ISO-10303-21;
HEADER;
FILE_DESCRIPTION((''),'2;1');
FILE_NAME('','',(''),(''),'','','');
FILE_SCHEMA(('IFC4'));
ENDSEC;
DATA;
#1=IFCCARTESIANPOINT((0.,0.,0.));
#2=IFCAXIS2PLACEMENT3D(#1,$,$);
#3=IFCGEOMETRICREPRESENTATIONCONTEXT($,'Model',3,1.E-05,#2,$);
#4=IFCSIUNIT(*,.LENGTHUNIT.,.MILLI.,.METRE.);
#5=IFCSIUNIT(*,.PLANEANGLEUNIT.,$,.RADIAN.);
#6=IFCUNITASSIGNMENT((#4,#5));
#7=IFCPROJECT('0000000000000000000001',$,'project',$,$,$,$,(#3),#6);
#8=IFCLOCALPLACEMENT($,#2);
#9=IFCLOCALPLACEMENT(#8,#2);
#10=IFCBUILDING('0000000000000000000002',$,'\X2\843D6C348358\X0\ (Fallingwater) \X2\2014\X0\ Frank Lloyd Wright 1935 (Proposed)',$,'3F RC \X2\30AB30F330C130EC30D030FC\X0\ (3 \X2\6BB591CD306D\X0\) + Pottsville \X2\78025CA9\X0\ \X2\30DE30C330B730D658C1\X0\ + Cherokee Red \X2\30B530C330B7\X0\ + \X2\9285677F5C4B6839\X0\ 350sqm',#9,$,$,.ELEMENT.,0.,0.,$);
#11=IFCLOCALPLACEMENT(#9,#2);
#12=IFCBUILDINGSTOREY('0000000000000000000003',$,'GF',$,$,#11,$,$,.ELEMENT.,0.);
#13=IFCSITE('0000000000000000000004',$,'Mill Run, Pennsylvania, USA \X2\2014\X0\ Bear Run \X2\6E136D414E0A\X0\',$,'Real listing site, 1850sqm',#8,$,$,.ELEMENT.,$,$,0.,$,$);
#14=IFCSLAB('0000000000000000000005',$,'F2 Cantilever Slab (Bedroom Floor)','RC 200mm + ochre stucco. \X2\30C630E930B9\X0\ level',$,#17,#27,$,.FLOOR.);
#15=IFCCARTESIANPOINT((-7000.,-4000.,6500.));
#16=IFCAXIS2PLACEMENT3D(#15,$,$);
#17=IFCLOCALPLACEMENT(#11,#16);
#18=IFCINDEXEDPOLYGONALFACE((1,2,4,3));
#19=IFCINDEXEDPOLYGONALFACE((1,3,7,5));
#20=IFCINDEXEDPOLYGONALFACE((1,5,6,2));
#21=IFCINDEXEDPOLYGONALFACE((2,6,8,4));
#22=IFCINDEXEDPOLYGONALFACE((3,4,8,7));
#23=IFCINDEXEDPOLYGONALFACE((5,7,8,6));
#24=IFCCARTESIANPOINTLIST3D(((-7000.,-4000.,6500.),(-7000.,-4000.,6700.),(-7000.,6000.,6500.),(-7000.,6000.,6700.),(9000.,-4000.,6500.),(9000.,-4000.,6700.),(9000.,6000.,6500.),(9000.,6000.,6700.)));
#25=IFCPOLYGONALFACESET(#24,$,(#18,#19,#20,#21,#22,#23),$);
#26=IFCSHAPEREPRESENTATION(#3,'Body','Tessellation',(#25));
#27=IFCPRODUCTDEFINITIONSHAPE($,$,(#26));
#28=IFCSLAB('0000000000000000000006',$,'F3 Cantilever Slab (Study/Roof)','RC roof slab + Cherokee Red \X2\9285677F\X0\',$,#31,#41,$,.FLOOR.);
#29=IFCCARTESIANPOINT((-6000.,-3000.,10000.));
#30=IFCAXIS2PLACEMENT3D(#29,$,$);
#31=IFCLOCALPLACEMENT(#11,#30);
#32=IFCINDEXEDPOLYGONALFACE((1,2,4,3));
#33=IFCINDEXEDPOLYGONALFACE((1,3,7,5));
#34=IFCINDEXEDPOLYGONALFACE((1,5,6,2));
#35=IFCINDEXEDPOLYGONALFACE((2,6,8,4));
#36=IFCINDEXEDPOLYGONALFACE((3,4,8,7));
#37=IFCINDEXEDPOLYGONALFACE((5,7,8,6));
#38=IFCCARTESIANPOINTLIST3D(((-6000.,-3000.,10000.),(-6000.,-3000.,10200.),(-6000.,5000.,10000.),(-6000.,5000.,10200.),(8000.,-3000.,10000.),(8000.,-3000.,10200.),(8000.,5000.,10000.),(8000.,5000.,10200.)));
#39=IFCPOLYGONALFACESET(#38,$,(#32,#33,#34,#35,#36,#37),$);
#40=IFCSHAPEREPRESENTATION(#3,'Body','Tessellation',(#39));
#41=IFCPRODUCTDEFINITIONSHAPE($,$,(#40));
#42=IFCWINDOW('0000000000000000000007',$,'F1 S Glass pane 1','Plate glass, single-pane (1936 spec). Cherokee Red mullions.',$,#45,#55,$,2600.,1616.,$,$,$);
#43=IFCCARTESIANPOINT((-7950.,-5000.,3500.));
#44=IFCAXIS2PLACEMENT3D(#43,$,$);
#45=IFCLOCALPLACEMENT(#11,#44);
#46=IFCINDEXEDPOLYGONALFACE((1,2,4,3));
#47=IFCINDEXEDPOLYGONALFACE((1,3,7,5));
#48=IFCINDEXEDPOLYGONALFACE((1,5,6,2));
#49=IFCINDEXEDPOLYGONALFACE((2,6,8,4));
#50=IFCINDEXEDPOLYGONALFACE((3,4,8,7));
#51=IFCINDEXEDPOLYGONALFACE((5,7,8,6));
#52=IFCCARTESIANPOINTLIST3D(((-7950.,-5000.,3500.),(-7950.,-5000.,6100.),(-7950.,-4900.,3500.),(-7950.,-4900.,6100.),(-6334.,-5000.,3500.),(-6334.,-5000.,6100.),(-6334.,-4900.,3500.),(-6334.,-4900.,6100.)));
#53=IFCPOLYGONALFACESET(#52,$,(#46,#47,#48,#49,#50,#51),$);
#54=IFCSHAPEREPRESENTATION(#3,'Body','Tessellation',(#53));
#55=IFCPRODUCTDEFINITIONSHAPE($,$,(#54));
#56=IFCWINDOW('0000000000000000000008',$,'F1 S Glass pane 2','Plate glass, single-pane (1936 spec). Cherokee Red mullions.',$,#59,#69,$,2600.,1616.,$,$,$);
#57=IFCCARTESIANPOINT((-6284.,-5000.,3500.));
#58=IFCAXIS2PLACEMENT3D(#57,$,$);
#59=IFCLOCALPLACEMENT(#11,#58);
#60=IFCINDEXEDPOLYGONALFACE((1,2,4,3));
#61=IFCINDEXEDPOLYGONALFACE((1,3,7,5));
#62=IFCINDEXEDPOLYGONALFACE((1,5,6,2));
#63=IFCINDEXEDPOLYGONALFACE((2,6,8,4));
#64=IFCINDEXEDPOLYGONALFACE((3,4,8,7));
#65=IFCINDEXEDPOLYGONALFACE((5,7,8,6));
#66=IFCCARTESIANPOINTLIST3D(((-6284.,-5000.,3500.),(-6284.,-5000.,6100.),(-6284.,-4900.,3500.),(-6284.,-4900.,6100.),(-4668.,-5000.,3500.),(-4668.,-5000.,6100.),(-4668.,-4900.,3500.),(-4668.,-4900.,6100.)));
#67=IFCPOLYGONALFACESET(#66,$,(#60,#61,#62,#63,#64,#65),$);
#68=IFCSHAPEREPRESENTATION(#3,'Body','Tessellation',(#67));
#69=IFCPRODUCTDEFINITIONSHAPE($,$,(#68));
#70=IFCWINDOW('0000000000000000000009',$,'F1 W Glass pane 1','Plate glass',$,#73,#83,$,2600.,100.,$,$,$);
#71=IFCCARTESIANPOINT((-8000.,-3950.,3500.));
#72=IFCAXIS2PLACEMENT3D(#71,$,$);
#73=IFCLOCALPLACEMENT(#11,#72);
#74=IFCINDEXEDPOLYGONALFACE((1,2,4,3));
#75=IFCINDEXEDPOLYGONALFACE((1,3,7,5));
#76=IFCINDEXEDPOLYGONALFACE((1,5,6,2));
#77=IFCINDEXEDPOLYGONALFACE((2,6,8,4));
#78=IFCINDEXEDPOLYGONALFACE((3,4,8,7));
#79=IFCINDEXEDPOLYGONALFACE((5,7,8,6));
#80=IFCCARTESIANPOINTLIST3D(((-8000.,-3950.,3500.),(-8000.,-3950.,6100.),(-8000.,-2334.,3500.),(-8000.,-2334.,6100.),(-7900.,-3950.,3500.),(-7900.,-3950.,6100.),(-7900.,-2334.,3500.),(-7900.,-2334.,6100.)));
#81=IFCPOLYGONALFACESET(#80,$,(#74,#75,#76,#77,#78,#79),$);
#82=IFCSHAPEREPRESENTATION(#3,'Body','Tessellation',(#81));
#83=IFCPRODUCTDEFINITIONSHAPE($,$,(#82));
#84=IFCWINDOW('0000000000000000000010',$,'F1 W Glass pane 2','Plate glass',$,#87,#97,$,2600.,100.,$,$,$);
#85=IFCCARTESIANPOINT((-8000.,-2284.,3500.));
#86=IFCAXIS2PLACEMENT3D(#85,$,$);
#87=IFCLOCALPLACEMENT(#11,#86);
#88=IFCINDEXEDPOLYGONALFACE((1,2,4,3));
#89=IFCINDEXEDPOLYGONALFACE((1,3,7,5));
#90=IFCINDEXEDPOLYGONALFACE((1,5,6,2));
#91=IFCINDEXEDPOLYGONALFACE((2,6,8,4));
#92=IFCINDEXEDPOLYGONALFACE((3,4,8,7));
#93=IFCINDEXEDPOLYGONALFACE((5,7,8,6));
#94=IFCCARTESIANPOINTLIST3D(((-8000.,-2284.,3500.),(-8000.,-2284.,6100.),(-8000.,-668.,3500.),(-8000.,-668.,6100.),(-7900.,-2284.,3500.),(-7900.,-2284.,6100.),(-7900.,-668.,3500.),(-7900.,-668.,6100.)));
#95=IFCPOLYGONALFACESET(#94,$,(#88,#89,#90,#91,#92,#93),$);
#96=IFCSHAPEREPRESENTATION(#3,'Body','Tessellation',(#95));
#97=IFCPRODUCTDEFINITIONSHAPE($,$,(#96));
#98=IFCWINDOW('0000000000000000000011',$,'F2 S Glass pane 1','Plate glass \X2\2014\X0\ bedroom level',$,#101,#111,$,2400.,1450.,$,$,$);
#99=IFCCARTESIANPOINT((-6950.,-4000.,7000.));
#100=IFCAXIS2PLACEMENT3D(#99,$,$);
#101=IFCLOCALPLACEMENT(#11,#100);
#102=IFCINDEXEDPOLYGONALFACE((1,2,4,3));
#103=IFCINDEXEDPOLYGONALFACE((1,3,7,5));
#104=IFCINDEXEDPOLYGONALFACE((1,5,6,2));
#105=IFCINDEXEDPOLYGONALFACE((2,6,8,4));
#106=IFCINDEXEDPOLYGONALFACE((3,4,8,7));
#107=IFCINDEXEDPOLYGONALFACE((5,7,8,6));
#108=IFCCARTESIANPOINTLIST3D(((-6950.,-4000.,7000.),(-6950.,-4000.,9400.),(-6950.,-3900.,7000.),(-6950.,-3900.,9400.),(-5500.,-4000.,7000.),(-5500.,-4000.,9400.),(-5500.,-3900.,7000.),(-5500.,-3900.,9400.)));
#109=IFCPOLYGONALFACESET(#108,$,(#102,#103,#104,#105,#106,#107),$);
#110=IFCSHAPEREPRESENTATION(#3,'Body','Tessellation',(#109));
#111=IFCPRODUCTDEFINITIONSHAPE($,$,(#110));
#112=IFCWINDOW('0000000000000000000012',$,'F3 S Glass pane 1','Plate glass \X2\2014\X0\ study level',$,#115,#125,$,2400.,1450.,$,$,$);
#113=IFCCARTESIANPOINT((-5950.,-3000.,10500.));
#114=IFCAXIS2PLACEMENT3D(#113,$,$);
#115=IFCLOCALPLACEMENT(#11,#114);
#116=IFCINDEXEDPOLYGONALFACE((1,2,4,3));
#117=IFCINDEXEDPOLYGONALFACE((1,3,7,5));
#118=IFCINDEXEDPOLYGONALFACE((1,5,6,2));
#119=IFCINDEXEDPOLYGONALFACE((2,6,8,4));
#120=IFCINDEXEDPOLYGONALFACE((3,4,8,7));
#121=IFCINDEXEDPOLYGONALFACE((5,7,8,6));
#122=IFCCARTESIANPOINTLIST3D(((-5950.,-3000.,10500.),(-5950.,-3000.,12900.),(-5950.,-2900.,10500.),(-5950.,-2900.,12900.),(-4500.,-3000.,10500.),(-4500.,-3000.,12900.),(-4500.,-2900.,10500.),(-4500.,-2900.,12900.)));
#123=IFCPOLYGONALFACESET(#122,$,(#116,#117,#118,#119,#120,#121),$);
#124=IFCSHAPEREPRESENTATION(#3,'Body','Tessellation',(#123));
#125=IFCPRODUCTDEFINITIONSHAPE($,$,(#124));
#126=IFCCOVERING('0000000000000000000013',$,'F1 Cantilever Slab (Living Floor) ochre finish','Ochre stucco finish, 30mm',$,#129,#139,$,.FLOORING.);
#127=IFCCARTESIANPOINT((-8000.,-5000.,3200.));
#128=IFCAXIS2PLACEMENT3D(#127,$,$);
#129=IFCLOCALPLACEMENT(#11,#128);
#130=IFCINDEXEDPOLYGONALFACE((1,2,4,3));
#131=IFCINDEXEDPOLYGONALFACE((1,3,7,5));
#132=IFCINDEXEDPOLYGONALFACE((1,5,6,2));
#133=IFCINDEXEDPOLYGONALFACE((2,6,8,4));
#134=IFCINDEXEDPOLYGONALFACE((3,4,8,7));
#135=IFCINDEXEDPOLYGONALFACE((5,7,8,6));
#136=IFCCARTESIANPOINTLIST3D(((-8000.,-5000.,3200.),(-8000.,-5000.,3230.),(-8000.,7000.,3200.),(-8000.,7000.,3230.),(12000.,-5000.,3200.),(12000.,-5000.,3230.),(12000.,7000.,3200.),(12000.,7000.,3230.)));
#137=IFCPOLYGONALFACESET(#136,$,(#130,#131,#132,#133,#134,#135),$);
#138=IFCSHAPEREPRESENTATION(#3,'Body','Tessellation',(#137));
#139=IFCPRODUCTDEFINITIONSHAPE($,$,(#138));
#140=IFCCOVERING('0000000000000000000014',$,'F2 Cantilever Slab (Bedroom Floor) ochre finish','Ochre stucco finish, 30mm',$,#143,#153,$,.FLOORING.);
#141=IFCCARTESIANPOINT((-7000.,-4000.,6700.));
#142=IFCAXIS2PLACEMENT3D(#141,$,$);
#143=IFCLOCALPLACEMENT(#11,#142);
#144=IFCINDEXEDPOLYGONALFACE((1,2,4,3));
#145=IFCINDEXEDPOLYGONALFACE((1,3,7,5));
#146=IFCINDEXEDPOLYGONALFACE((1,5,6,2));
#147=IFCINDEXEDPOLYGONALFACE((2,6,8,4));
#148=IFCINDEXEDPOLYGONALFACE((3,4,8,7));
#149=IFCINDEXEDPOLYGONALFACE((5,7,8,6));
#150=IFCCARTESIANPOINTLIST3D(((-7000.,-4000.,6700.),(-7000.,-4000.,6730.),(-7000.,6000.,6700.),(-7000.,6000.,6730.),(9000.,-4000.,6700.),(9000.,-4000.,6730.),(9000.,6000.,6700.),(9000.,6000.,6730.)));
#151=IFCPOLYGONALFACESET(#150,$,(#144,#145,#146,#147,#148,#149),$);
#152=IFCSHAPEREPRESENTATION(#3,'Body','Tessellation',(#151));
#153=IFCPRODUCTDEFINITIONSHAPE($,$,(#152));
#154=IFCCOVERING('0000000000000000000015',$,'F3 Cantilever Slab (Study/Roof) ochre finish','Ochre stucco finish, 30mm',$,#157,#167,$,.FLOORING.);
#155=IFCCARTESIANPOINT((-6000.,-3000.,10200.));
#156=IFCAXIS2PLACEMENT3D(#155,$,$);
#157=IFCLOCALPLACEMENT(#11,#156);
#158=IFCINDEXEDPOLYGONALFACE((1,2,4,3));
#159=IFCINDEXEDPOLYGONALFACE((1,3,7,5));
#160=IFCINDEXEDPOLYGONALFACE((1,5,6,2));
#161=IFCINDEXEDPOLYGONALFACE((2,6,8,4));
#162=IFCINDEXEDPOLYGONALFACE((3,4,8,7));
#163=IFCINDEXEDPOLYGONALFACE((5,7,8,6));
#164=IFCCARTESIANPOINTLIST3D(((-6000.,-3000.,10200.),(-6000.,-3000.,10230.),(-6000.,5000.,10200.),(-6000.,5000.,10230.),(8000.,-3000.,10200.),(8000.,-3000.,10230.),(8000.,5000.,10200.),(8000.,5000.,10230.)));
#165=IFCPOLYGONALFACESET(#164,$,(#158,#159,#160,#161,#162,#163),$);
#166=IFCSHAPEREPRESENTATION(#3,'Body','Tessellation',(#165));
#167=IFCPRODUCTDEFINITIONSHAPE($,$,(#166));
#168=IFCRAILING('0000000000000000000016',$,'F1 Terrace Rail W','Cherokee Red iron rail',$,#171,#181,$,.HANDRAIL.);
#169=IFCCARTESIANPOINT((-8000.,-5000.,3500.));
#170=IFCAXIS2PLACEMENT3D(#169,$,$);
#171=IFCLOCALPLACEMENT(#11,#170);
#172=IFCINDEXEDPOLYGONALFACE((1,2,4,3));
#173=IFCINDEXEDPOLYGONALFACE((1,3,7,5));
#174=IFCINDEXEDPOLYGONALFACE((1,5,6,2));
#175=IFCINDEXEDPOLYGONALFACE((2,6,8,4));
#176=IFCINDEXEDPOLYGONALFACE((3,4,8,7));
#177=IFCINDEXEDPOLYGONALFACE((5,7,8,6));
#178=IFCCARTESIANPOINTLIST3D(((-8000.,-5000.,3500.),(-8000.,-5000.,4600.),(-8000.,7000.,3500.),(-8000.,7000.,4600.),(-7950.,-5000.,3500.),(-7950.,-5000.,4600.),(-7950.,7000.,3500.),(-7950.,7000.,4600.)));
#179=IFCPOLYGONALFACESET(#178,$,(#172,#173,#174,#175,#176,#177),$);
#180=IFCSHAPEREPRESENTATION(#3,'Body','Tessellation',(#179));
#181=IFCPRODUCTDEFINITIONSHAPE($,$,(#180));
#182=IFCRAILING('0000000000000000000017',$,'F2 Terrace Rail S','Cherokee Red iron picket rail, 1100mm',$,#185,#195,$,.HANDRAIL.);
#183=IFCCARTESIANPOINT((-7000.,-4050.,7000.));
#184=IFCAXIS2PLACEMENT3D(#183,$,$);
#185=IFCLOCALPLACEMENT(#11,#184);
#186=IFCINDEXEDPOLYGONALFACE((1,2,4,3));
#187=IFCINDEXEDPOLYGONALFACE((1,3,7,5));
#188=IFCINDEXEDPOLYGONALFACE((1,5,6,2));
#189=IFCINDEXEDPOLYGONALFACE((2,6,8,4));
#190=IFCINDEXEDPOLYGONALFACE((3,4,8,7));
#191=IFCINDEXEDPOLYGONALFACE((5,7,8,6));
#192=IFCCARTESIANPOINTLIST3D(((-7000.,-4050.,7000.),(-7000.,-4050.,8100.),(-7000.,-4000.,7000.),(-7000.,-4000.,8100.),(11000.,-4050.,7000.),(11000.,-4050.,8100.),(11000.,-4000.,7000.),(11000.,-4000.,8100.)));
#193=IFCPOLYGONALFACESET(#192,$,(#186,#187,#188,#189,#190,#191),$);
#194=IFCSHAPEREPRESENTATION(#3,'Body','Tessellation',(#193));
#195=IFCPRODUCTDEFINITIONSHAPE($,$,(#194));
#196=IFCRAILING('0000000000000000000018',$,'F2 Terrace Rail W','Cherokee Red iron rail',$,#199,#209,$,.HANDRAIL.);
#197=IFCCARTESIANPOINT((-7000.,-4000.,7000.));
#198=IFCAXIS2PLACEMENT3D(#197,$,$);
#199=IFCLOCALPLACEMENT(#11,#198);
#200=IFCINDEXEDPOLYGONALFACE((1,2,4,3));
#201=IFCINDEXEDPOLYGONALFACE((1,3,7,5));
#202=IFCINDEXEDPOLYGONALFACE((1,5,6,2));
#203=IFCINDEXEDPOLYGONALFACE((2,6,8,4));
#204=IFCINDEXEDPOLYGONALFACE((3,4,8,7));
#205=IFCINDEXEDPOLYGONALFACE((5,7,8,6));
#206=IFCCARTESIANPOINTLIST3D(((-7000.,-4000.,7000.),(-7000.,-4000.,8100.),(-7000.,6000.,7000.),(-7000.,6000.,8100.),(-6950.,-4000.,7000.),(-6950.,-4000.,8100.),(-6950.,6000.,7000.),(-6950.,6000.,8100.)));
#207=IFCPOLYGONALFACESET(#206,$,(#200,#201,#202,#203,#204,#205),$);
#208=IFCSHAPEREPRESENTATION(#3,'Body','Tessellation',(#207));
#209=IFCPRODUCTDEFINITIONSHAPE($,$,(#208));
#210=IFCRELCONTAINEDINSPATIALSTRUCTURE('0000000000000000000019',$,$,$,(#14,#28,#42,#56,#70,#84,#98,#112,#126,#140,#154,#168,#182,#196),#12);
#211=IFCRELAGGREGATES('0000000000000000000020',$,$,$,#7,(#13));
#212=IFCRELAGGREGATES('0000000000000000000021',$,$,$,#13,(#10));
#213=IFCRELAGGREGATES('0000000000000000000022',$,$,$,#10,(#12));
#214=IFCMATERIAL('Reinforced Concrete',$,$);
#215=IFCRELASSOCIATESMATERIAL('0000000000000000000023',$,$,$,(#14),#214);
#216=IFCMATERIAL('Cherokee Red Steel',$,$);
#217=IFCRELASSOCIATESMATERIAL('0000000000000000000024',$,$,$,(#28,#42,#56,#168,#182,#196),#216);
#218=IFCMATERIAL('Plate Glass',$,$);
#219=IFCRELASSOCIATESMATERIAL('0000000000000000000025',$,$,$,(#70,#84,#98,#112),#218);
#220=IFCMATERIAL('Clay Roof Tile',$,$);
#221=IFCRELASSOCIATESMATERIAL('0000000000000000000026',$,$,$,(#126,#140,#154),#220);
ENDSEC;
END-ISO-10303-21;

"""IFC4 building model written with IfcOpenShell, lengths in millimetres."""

from ifc_helpers import new_model, si_unit, frame, frame_2d, origin, place, context, project, spatial, rectangle, extrude, material, element, save


model = new_model("IFC4")

# Units and contexts
model_context = context("Model", 3, precision=1e-05, world=origin())
ifc_project = project(units=[si_unit("LENGTHUNIT", "METRE", prefix="MILLI"), si_unit("PLANEANGLEUNIT", "RADIAN")], contexts=[model_context])

# Site, building, storey
site_placement = place(None, origin())
site = spatial("IfcSite", under=ifc_project, at=site_placement, Name="Mill Run, Pennsylvania, USA — Bear Run 渓流上", ObjectType="Real listing site, 1850sqm", CompositionType="ELEMENT", RefElevation=0.0)
building_placement = place(site_placement, origin())
building = spatial("IfcBuilding", under=site, at=building_placement, Name="落水荘 (Fallingwater) — Frank Lloyd Wright 1935 (Proposed)", ObjectType="3F RC カンチレバー (3 段重ね) + Pottsville 砂岩 マッシブ壁 + Cherokee Red サッシ + 銅板屋根 350sqm", CompositionType="ELEMENT", ElevationOfRefHeight=0.0, ElevationOfTerrain=0.0)
storey_placement = place(building_placement, origin())
storey = spatial("IfcBuildingStorey", under=building, at=storey_placement, Name="GF", CompositionType="ELEMENT", Elevation=0.0)

# Slabs
ifc_material_1 = material(Name="Reinforced Concrete")
slab_1_placement = place(storey_placement, frame((-7000.0, -4000.0, 6500.0)))
element("IfcSlab", 1, at=slab_1_placement, inside=storey, material=ifc_material_1, Name="F2 Cantilever Slab (Bedroom Floor)", Description="RC 200mm + ochre stucco. テラス level", PredefinedType="FLOOR", context=model_context, shape_type="SweptSolid", body=[
    extrude(rectangle(XDim=16000.0, YDim=10000.0, at=frame_2d((8000.0, 5000.0))), frame((-7000.0, -4000.0, 6500.0)), (0.0, 0.0, 1.0), 200.0),
])
ifc_material_2 = material(Name="Cherokee Red Steel")
slab_2_placement = place(storey_placement, frame((-6000.0, -3000.0, 10000.0)))
element("IfcSlab", 2, at=slab_2_placement, inside=storey, material=ifc_material_2, Name="F3 Cantilever Slab (Study/Roof)", Description="RC roof slab + Cherokee Red 銅板", PredefinedType="FLOOR", context=model_context, shape_type="SweptSolid", body=[
    extrude(rectangle(XDim=14000.0, YDim=8000.0, at=frame_2d((7000.0, 4000.0))), frame((-6000.0, -3000.0, 10000.0)), (0.0, 0.0, 1.0), 200.0),
])

# Windows
window_1_placement = place(storey_placement, frame((-7950.0, -5000.0, 3500.0)))
element("IfcWindow", 3, at=window_1_placement, inside=storey, material=ifc_material_2, Name="F1 S Glass pane 1", Description="Plate glass, single-pane (1936 spec). Cherokee Red mullions.", OverallHeight=2600.0, OverallWidth=1616.0, context=model_context, shape_type="SweptSolid", body=[
    extrude(rectangle(XDim=1616.0, YDim=100.0, at=frame_2d((808.0, 50.0))), frame((-7950.0, -5000.0, 3500.0)), (0.0, 0.0, 1.0), 2600.0),
])
window_2_placement = place(storey_placement, frame((-6284.0, -5000.0, 3500.0)))
element("IfcWindow", 4, at=window_2_placement, inside=storey, material=ifc_material_2, Name="F1 S Glass pane 2", Description="Plate glass, single-pane (1936 spec). Cherokee Red mullions.", OverallHeight=2600.0, OverallWidth=1616.0, context=model_context, shape_type="SweptSolid", body=[
    extrude(rectangle(XDim=1616.0, YDim=100.0, at=frame_2d((808.0, 50.0))), frame((-6284.0, -5000.0, 3500.0)), (0.0, 0.0, 1.0), 2600.0),
])
ifc_material_3 = material(Name="Plate Glass")
window_3_placement = place(storey_placement, frame((-8000.0, -3950.0, 3500.0)))
element("IfcWindow", 5, at=window_3_placement, inside=storey, material=ifc_material_3, Name="F1 W Glass pane 1", Description="Plate glass", OverallHeight=2600.0, OverallWidth=100.0, context=model_context, shape_type="SweptSolid", body=[
    extrude(rectangle(XDim=100.0, YDim=1616.0, at=frame_2d((50.0, 808.0))), frame((-8000.0, -3950.0, 3500.0)), (0.0, 0.0, 1.0), 2600.0),
])
window_4_placement = place(storey_placement, frame((-8000.0, -2284.0, 3500.0)))
element("IfcWindow", 6, at=window_4_placement, inside=storey, material=ifc_material_3, Name="F1 W Glass pane 2", Description="Plate glass", OverallHeight=2600.0, OverallWidth=100.0, context=model_context, shape_type="SweptSolid", body=[
    extrude(rectangle(XDim=100.0, YDim=1616.0, at=frame_2d((50.0, 808.0))), frame((-8000.0, -2284.0, 3500.0)), (0.0, 0.0, 1.0), 2600.0),
])
window_5_placement = place(storey_placement, frame((-6950.0, -4000.0, 7000.0)))
element("IfcWindow", 7, at=window_5_placement, inside=storey, material=ifc_material_3, Name="F2 S Glass pane 1", Description="Plate glass — bedroom level", OverallHeight=2400.0, OverallWidth=1450.0, context=model_context, shape_type="SweptSolid", body=[
    extrude(rectangle(XDim=1450.0, YDim=100.0, at=frame_2d((725.0, 50.0))), frame((-6950.0, -4000.0, 7000.0)), (0.0, 0.0, 1.0), 2400.0),
])
window_6_placement = place(storey_placement, frame((-5950.0, -3000.0, 10500.0)))
element("IfcWindow", 8, at=window_6_placement, inside=storey, material=ifc_material_3, Name="F3 S Glass pane 1", Description="Plate glass — study level", OverallHeight=2400.0, OverallWidth=1450.0, context=model_context, shape_type="SweptSolid", body=[
    extrude(rectangle(XDim=1450.0, YDim=100.0, at=frame_2d((725.0, 50.0))), frame((-5950.0, -3000.0, 10500.0)), (0.0, 0.0, 1.0), 2400.0),
])

# Coverings
ifc_material_4 = material(Name="Clay Roof Tile")
covering_1_placement = place(storey_placement, frame((-8000.0, -5000.0, 3200.0)))
element("IfcCovering", 9, at=covering_1_placement, inside=storey, material=ifc_material_4, Name="F1 Cantilever Slab (Living Floor) ochre finish", Description="Ochre stucco finish, 30mm", PredefinedType="FLOORING", context=model_context, shape_type="SweptSolid", body=[
    extrude(rectangle(XDim=20000.0, YDim=12000.0, at=frame_2d((10000.0, 6000.0))), frame((-8000.0, -5000.0, 3200.0)), (0.0, 0.0, 1.0), 30.0),
])
covering_2_placement = place(storey_placement, frame((-7000.0, -4000.0, 6700.0)))
element("IfcCovering", 10, at=covering_2_placement, inside=storey, material=ifc_material_4, Name="F2 Cantilever Slab (Bedroom Floor) ochre finish", Description="Ochre stucco finish, 30mm", PredefinedType="FLOORING", context=model_context, shape_type="SweptSolid", body=[
    extrude(rectangle(XDim=16000.0, YDim=10000.0, at=frame_2d((8000.0, 5000.0))), frame((-7000.0, -4000.0, 6700.0)), (0.0, 0.0, 1.0), 30.0),
])
covering_3_placement = place(storey_placement, frame((-6000.0, -3000.0, 10200.0)))
element("IfcCovering", 11, at=covering_3_placement, inside=storey, material=ifc_material_4, Name="F3 Cantilever Slab (Study/Roof) ochre finish", Description="Ochre stucco finish, 30mm", PredefinedType="FLOORING", context=model_context, shape_type="SweptSolid", body=[
    extrude(rectangle(XDim=14000.0, YDim=8000.0, at=frame_2d((7000.0, 4000.0))), frame((-6000.0, -3000.0, 10200.0)), (0.0, 0.0, 1.0), 30.0),
])

# Railings
railing_1_placement = place(storey_placement, frame((-8000.0, -5000.0, 3500.0)))
element("IfcRailing", 12, at=railing_1_placement, inside=storey, material=ifc_material_2, Name="F1 Terrace Rail W", Description="Cherokee Red iron rail", PredefinedType="HANDRAIL", context=model_context, shape_type="SweptSolid", body=[
    extrude(rectangle(XDim=50.0, YDim=12000.0, at=frame_2d((25.0, 6000.0))), frame((-8000.0, -5000.0, 3500.0)), (0.0, 0.0, 1.0), 1100.0),
])
railing_2_placement = place(storey_placement, frame((-7000.0, -4050.0, 7000.0)))
element("IfcRailing", 13, at=railing_2_placement, inside=storey, material=ifc_material_2, Name="F2 Terrace Rail S", Description="Cherokee Red iron picket rail, 1100mm", PredefinedType="HANDRAIL", context=model_context, shape_type="SweptSolid", body=[
    extrude(rectangle(XDim=18000.0, YDim=50.0, at=frame_2d((9000.0, 25.0))), frame((-7000.0, -4050.0, 7000.0)), (0.0, 0.0, 1.0), 1100.0),
])
railing_3_placement = place(storey_placement, frame((-7000.0, -4000.0, 7000.0)))
element("IfcRailing", 14, at=railing_3_placement, inside=storey, material=ifc_material_2, Name="F2 Terrace Rail W", Description="Cherokee Red iron rail", PredefinedType="HANDRAIL", context=model_context, shape_type="SweptSolid", body=[
    extrude(rectangle(XDim=50.0, YDim=10000.0, at=frame_2d((25.0, 5000.0))), frame((-7000.0, -4000.0, 7000.0)), (0.0, 0.0, 1.0), 1100.0),
])

save(model, "model.ifc")
